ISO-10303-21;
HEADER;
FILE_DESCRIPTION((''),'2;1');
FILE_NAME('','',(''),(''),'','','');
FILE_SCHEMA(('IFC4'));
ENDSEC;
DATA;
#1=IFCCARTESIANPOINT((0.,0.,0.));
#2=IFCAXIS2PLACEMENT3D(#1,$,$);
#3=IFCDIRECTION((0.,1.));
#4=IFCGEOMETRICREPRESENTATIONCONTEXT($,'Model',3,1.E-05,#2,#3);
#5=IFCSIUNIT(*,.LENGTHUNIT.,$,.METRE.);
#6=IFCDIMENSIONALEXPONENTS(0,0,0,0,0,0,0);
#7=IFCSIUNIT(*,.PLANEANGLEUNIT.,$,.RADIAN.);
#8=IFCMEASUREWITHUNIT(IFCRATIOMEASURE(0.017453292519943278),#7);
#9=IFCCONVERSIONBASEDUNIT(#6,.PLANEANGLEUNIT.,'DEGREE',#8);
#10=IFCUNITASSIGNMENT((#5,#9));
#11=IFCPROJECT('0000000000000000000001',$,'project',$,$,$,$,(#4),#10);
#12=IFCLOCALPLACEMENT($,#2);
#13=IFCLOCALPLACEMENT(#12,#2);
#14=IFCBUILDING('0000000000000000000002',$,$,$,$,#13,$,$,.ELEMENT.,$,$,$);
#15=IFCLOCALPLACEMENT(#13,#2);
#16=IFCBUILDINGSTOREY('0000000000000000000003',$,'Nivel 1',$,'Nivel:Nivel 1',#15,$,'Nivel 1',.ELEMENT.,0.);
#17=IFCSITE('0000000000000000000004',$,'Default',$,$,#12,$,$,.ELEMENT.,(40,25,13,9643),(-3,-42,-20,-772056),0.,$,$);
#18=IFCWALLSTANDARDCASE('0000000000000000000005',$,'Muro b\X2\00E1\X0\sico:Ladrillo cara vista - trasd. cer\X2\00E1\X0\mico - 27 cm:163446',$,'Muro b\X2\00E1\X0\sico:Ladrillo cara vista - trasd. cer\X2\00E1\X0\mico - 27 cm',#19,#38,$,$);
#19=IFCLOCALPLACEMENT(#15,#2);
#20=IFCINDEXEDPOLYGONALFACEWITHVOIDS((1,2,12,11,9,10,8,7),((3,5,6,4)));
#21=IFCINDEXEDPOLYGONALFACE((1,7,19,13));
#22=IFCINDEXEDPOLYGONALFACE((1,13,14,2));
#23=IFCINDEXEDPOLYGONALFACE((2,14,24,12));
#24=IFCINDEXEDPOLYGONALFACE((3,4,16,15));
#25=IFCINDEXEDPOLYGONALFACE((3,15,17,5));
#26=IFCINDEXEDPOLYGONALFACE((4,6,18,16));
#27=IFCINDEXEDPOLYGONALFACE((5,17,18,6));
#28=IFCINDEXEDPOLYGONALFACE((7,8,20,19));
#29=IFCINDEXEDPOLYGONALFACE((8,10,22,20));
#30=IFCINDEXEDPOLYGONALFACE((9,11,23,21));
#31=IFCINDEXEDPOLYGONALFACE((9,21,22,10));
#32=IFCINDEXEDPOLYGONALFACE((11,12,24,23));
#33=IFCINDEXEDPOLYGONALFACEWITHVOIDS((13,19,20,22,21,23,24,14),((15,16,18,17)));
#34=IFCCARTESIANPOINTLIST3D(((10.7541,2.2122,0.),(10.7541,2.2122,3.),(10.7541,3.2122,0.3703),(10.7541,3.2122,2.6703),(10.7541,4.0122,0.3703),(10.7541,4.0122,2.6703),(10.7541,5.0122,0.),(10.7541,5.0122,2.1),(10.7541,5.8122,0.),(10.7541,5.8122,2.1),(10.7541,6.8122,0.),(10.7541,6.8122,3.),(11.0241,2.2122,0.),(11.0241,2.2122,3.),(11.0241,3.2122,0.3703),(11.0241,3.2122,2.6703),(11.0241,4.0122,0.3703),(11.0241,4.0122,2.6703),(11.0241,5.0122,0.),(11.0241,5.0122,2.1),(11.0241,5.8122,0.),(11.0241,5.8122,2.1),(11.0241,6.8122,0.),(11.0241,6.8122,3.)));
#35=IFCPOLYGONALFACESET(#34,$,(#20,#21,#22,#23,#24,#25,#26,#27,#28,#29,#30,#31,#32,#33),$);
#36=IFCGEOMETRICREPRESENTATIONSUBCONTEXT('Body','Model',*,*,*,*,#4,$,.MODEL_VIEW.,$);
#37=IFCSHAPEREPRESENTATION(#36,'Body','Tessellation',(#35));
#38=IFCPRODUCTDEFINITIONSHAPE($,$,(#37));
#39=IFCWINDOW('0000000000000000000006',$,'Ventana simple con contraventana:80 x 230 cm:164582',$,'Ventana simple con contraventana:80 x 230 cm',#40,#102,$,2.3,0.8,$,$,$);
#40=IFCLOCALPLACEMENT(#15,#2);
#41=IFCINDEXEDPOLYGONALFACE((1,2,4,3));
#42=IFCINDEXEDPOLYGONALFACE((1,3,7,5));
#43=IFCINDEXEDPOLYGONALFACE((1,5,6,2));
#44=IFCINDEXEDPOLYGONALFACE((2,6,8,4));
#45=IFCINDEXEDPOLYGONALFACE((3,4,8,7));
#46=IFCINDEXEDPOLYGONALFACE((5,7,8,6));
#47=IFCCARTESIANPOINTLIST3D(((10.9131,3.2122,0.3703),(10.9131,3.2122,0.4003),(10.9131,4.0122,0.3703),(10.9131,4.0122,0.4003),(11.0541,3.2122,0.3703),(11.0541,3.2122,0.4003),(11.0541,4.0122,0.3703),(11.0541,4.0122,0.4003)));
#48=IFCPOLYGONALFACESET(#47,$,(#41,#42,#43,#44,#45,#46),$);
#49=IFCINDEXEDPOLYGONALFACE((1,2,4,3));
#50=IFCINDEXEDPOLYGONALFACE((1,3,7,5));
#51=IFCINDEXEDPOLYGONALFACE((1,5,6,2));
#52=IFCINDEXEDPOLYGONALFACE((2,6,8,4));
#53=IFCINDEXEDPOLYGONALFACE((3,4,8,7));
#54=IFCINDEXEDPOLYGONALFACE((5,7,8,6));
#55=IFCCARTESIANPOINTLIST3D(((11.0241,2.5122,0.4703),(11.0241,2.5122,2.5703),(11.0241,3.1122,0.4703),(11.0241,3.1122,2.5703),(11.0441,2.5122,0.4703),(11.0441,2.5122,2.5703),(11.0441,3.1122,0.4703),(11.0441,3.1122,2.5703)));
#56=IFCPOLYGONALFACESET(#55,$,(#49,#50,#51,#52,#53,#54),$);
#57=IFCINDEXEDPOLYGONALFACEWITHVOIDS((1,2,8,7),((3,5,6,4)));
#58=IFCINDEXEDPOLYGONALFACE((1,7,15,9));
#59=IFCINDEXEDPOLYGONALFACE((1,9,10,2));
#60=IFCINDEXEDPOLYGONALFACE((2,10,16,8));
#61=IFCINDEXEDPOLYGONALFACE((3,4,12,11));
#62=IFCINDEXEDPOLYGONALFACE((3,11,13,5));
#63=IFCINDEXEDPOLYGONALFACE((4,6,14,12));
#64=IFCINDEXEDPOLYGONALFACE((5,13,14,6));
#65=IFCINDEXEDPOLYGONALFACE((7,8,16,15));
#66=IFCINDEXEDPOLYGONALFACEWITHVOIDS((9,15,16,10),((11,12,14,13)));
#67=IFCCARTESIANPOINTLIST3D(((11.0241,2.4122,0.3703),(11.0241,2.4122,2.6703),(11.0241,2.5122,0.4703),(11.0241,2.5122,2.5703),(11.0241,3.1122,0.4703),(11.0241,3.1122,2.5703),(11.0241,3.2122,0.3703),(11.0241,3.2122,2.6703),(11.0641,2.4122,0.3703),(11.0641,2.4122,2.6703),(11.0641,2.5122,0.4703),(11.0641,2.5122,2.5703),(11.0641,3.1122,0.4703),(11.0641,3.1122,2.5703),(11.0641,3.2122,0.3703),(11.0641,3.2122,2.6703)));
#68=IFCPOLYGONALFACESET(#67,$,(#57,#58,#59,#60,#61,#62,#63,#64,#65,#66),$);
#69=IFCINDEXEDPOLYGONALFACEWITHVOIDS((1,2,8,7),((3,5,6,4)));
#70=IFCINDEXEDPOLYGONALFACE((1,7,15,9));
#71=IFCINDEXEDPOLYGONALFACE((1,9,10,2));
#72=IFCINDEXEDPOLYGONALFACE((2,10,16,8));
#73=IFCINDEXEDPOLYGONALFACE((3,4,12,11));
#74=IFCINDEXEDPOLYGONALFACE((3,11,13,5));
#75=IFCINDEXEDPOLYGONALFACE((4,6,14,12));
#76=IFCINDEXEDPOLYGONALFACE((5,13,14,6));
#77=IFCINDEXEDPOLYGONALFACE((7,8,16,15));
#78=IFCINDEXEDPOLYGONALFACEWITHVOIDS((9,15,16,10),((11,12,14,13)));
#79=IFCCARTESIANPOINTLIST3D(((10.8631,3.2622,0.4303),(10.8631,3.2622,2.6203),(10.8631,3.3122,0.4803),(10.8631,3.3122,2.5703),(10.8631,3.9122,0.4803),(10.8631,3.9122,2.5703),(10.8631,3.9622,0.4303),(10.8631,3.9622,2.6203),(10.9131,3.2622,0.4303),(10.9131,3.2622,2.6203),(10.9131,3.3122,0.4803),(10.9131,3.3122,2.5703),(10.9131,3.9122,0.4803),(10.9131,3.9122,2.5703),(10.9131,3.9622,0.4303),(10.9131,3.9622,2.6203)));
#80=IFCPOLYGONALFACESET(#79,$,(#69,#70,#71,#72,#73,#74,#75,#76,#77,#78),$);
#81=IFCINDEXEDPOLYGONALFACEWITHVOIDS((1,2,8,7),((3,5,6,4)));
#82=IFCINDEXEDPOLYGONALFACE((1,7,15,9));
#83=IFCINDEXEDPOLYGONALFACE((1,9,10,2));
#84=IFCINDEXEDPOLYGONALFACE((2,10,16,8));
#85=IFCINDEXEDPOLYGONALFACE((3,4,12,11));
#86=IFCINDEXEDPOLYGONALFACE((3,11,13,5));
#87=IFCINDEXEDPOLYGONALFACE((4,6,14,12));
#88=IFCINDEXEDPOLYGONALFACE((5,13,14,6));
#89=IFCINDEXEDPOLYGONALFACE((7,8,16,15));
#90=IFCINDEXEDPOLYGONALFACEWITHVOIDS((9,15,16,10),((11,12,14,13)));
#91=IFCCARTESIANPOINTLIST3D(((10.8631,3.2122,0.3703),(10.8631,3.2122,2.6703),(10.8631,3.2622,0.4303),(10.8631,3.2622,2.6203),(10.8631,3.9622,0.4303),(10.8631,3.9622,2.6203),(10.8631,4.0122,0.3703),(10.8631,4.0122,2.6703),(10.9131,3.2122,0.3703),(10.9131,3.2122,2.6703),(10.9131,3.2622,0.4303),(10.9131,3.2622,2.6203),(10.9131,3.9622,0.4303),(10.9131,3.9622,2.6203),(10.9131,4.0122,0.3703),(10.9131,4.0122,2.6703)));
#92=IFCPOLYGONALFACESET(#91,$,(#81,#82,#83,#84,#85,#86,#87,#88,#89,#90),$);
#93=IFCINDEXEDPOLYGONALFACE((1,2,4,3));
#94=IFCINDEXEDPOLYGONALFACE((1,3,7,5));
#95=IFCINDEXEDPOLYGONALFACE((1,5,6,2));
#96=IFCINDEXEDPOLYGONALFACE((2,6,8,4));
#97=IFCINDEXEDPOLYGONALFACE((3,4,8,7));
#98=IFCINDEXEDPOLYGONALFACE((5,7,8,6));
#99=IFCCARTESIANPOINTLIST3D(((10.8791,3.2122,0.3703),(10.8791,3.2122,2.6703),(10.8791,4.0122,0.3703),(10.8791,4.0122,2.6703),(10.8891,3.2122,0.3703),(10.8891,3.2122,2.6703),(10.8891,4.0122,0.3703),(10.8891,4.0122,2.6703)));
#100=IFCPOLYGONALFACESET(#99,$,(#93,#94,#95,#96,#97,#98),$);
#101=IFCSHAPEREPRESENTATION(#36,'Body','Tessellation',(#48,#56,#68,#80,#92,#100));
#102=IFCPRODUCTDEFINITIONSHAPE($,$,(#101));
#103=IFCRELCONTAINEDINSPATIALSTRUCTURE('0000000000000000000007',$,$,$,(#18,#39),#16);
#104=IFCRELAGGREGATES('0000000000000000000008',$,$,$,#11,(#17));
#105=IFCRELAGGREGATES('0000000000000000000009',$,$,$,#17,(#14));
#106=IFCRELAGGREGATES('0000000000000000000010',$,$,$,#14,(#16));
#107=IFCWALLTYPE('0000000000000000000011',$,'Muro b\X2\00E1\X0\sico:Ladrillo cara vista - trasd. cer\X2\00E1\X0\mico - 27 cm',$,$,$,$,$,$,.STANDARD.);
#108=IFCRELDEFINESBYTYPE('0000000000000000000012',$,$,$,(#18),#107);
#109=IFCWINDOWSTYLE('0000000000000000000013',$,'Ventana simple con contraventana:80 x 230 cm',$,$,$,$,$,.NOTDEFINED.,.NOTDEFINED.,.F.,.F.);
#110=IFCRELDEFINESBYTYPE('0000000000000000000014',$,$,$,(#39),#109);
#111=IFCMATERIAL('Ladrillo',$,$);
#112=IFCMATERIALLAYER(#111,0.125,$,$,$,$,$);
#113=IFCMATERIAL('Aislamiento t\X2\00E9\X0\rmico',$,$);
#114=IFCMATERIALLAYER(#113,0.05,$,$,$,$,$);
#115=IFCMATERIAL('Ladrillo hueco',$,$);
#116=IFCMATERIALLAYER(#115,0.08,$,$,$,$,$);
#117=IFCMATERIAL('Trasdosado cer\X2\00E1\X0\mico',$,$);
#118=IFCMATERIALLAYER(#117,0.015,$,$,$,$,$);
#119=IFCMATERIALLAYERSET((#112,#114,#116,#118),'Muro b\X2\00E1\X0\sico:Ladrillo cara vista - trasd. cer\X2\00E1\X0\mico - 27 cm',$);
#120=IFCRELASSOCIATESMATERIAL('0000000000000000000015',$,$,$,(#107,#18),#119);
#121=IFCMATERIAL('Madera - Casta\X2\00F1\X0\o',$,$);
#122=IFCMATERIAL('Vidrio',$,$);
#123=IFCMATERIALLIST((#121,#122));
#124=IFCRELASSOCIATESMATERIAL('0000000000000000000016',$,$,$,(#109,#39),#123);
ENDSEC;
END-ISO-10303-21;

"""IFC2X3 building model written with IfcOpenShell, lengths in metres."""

from ifc_helpers import new_model, entity, si_unit, converted_unit, direction, frame, frame_2d, origin, origin_2d_with_axis, place, context, subcontext, project, spatial, polyline, rectangle, outline, extrude, source, transform, mapped, material, material_list, layer, layer_set, layer_usage, type_object, type_shapes, element, fill, save


model = new_model("IFC2X3")

# Units and contexts
model_context = context("Model", 3, precision=1e-05, world=origin(), true_north=direction((0.0, 1.0)))
body_context = subcontext(model_context, "Body", "Model", "MODEL_VIEW")
ifc_project = project(units=[si_unit("LENGTHUNIT", "METRE"), converted_unit("PLANEANGLEUNIT", "DEGREE", entity("IfcRatioMeasure", 0.017453292519943278), si_unit("PLANEANGLEUNIT", "RADIAN"), dimensions=[0, 0, 0, 0, 0, 0, 0])], contexts=[model_context])

# Site, building, storey
site_placement = place(None, origin())
site = spatial("IfcSite", under=ifc_project, at=site_placement, Name="Default", CompositionType="ELEMENT", RefLatitude=(40, 25, 13, 9643), RefLongitude=(-3, -42, -20, -772056), RefElevation=0.0)
building_placement = place(site_placement, origin())
building = spatial("IfcBuilding", under=site, at=building_placement, CompositionType="ELEMENT")
storey_placement = place(building_placement, origin())
storey = spatial("IfcBuildingStorey", under=building, at=storey_placement, Name="Nivel 1", ObjectType="Nivel:Nivel 1", LongName="Nivel 1", CompositionType="ELEMENT", Elevation=0.0)

# Shared definitions
ifc_material_1 = material(Name="Ladrillo")

# Wall, openings, window
ifc_layer_1 = layer(ifc_material_1, 0.125)
ifc_material_2 = material(Name="Aislamiento térmico")
ifc_layer_2 = layer(ifc_material_2, 0.05)
ifc_material_3 = material(Name="Ladrillo hueco")
ifc_layer_3 = layer(ifc_material_3, 0.08)
ifc_material_4 = material(Name="Trasdosado cerámico")
ifc_layer_4 = layer(ifc_material_4, 0.015)
ifc_layer_set_1 = layer_set([ifc_layer_1, ifc_layer_2, ifc_layer_3, ifc_layer_4], Name="Muro básico:Ladrillo cara vista - trasd. cerámico - 27 cm")
ifc_layer_usage_1 = layer_usage(ifc_layer_set_1, "AXIS2", "NEGATIVE", 0.135)
wall_type_1 = type_object("IfcWallType", Name="Muro básico:Ladrillo cara vista - trasd. cerámico - 27 cm", PredefinedType="STANDARD", material=ifc_layer_set_1)
wall_1_placement = place(storey_placement, frame((10.8891, 6.8122, 0.0), z_axis=(0.0, 0.0, 1.0), x_axis=(0.0, -1.0, 0.0)))
wall_1 = element("IfcWallStandardCase", 1, at=wall_1_placement, inside=storey, type_object=wall_type_1, material=ifc_layer_usage_1, Name="Muro básico:Ladrillo cara vista - trasd. cerámico - 27 cm:163446", ObjectType="Muro básico:Ladrillo cara vista - trasd. cerámico - 27 cm", context=body_context, shape_type="SweptSolid", body=[
    extrude(rectangle(XDim=4.6, YDim=0.27, at=frame_2d((2.3, 0.0), x_axis=(1.0, 0.0))), origin(), (0.0, 0.0, 1.0), 3.0),
])
opening_1_placement = place(wall_1_placement, frame((1.0, -0.135, 0.0)))
element("IfcOpeningElement", 2, at=opening_1_placement, cuts=wall_1, ObjectType="Opening", context=body_context, shape_type="SweptSolid", body=[
    extrude(rectangle(XDim=2.1, YDim=0.8, at=frame_2d((1.05, 0.4), x_axis=(1.0, 0.0))), frame((0.0, 0.0, 0.0), z_axis=(0.0, 1.0, 0.0), x_axis=(0.0, 0.0, 1.0)), (0.0, 0.0, 1.0), 0.27),
])
opening_2_placement = place(wall_1_placement, frame((2.8, -0.135, 0.3703)))
opening_2 = element("IfcOpeningElement", 3, at=opening_2_placement, cuts=wall_1, ObjectType="Opening", context=body_context, shape_type="SweptSolid", body=[
    extrude(rectangle(XDim=2.3, YDim=0.8, at=frame_2d((1.15, 0.4), x_axis=(1.0, 0.0))), frame((0.0, 0.0, 0.0), z_axis=(0.0, 1.0, 0.0), x_axis=(0.0, 0.0, 1.0)), (0.0, 0.0, 1.0), 0.27),
])
ifc_material_5 = material(Name="Madera - Castaño")
ifc_material_6 = material(Name="Vidrio")
ifc_material_list = material_list([ifc_material_5, ifc_material_6])
window_style = type_object("IfcWindowStyle", Name="Ventana simple con contraventana:80 x 230 cm", ConstructionType="NOTDEFINED", OperationType="NOTDEFINED", ParameterTakesPrecedence=False, Sizeable=False, material=ifc_material_list)
shared_shape_1 = source(origin(), body_context, "Body", "SweptSolid", [
    extrude(rectangle(XDim=0.8, YDim=0.141, at=frame_2d((0.0, 0.0), x_axis=(1.0, 0.0))), frame((0.4, 0.2295, 0.0)), (0.0, 0.0, 1.0), 0.03),
    extrude(rectangle(XDim=0.02, YDim=0.6, at=frame_2d((0.0, 0.0), x_axis=(1.0, 0.0))), frame((1.2, 0.28, 0.1), z_axis=(0.0, 0.0, 1.0), x_axis=(0.0, 1.0, 0.0)), (0.0, 0.0, 1.0), 2.1),
    extrude(outline(polyline([(-1.15, -0.4), (1.15, -0.4), (1.15, 0.4), (-1.15, 0.4), (-1.15, -0.4)]), holes=[polyline([(-1.05, 0.3), (1.05, 0.3), (1.05, -0.3), (-1.05, -0.3), (-1.05, 0.3)])]), frame((1.2, 0.27, 1.15), z_axis=(0.0, 1.0, 0.0), x_axis=(0.0, 0.0, -1.0)), (0.0, 0.0, 1.0), 0.04),
    extrude(outline(polyline([(-1.095, -0.35), (1.095, -0.35), (1.095, 0.35), (-1.095, 0.35), (-1.095, -0.35)]), holes=[polyline([(-1.045, -0.3), (-1.045, 0.3), (1.045, 0.3), (1.045, -0.3), (-1.045, -0.3)])]), frame((0.4, 0.109, 1.155), z_axis=(0.0, 1.0, 0.0), x_axis=(0.0, 0.0, -1.0)), (0.0, 0.0, 1.0), 0.05),
    extrude(outline(polyline([(-0.4, -1.15), (0.4, -1.15), (0.4, 1.15), (-0.4, 1.15), (-0.4, -1.15)]), holes=[polyline([(-0.35, -1.1), (-0.35, 1.09), (0.35, 1.09), (0.35, -1.1), (-0.35, -1.1)])]), frame((0.4, 0.109, 1.15), z_axis=(0.0, 1.0, 0.0), x_axis=(1.0, 0.0, 0.0)), (0.0, 0.0, 1.0), 0.05),
    extrude(rectangle(XDim=0.01, YDim=0.8, at=origin_2d_with_axis()), frame((0.4, 0.13, 0.0), z_axis=(0.0, 0.0, 1.0), x_axis=(0.0, 1.0, 0.0)), (0.0, 0.0, 1.0), 2.3),
])
type_shapes(window_style, [shared_shape_1])
window_placement = place(opening_2_placement, origin())
window = element("IfcWindow", 4, at=window_placement, inside=storey, type_object=window_style, material=ifc_material_list, Name="Ventana simple con contraventana:80 x 230 cm:164582", ObjectType="Ventana simple con contraventana:80 x 230 cm", OverallHeight=2.3, OverallWidth=0.8, context=body_context, shape_type="MappedRepresentation", body=[
    mapped(shared_shape_1, transform((0.0, 0.0, 0.0), scale=1.0)),
])
fill(opening_2, window)

save(model, "model.ifc")
